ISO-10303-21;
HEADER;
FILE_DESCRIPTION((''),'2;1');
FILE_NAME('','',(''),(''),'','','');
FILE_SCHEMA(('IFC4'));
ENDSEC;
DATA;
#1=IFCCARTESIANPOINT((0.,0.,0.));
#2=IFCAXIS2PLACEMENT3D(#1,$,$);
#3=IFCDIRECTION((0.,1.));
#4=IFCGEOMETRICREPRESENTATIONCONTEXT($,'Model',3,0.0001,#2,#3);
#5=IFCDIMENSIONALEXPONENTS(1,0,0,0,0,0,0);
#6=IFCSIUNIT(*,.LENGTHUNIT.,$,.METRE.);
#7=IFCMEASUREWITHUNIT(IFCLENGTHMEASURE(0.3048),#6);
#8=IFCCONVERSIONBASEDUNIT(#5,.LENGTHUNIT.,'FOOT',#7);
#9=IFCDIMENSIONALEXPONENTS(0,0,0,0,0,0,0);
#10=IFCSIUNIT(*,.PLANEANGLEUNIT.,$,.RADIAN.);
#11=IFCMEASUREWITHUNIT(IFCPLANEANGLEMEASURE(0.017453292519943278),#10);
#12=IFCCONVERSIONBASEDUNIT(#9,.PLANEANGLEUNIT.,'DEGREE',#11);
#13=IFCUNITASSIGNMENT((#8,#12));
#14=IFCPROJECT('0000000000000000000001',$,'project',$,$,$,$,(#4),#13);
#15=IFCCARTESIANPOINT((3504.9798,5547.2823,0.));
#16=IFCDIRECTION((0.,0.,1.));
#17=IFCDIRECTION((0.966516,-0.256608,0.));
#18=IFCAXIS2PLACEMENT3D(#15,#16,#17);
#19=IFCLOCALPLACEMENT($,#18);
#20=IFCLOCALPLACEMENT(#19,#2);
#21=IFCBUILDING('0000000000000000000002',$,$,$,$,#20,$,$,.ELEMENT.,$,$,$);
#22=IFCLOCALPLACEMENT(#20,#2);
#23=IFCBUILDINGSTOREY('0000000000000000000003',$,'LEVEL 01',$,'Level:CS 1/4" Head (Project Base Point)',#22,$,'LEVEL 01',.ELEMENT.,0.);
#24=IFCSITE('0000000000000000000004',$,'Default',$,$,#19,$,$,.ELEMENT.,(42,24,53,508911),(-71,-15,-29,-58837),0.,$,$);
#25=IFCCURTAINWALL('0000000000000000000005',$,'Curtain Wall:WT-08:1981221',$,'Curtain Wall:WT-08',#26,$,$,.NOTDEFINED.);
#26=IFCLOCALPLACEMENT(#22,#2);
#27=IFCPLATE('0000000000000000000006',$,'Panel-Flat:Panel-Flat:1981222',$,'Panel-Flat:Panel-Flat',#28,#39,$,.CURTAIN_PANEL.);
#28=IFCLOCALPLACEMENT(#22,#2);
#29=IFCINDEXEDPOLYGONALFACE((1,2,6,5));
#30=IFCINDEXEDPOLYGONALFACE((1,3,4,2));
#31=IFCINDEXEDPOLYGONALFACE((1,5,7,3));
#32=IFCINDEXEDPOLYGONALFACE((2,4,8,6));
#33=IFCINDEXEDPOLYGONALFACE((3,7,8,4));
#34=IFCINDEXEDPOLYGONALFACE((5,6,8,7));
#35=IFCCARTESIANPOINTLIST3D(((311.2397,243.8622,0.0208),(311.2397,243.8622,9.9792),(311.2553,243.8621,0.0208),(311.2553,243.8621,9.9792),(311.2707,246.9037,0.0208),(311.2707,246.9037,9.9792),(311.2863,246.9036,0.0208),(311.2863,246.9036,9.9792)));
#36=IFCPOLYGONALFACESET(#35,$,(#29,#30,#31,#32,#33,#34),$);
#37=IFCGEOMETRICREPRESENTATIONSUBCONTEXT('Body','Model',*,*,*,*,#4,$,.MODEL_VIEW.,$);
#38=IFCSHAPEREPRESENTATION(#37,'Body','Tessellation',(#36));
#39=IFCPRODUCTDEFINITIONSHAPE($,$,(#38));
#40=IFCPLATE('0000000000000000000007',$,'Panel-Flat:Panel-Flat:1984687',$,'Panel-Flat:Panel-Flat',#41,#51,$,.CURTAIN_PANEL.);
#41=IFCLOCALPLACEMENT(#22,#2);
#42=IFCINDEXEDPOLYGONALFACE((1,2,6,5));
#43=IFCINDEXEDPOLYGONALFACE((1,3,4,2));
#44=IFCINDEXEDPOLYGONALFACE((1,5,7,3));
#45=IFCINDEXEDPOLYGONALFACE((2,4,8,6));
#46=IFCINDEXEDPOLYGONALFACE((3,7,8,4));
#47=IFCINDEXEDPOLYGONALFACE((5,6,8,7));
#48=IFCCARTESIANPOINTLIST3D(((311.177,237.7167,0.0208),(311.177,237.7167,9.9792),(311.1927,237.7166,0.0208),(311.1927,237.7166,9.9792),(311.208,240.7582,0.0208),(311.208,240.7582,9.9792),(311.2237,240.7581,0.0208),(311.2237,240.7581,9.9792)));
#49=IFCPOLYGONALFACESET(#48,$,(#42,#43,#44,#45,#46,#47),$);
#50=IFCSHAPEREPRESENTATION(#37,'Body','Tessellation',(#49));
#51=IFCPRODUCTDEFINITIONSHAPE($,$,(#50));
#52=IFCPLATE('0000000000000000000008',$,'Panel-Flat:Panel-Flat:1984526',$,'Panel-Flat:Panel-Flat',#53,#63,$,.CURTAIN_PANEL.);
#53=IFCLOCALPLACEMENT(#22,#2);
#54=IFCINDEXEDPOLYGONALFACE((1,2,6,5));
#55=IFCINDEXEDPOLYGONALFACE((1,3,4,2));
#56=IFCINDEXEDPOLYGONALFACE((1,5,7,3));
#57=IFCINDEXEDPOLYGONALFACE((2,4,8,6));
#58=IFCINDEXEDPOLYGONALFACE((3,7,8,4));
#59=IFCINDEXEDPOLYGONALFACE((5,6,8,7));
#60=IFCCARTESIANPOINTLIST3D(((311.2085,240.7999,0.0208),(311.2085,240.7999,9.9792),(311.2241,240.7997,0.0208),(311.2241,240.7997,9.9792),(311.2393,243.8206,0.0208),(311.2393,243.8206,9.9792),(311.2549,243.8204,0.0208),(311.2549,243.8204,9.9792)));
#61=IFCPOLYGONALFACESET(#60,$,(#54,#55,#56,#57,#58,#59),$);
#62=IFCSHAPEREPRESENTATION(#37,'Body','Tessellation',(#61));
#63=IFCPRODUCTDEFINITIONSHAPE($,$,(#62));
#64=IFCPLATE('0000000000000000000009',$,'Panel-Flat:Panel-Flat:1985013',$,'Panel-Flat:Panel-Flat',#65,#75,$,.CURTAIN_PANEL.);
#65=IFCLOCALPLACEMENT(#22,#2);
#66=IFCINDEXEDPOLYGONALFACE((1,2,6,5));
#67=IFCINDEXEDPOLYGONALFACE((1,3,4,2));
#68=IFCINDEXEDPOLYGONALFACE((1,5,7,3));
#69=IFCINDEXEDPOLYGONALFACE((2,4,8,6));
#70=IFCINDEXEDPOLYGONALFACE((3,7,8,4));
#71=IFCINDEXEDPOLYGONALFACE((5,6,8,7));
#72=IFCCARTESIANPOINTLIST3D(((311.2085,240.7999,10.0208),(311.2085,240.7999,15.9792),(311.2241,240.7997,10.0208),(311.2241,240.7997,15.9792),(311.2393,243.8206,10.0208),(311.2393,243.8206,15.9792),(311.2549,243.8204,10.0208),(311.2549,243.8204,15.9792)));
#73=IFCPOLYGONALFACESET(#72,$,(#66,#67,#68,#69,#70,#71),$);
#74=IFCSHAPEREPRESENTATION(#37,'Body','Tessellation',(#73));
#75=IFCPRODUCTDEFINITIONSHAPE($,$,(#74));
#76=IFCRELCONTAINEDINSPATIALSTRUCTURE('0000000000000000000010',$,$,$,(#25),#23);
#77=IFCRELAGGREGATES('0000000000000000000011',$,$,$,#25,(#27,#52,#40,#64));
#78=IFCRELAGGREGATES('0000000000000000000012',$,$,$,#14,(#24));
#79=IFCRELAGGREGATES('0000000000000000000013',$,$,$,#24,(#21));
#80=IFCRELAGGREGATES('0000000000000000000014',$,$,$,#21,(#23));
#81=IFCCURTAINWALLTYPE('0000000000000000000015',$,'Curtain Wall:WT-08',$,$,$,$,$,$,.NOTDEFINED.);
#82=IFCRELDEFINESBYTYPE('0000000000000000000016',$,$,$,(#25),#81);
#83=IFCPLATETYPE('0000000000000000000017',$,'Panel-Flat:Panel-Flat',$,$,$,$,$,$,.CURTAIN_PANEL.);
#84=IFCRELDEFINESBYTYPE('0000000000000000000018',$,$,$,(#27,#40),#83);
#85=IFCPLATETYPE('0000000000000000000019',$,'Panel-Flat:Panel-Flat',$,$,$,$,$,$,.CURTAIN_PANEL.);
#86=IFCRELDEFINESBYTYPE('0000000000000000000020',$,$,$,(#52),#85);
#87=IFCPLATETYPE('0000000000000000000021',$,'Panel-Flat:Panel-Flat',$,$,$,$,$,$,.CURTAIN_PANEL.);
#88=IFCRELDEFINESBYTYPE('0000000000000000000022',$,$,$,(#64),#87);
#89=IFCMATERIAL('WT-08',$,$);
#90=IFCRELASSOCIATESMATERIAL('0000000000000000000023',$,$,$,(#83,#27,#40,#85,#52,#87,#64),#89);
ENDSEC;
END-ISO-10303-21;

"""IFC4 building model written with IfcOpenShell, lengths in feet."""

from ifc_helpers import new_model, entity, si_unit, converted_unit, direction, frame, origin, place, context, subcontext, project, spatial, indexed_curve, outline, extrude, source, transform, mapped, material, type_object, type_shapes, element, aggregate, save


model = new_model("IFC4")

# Units and contexts
model_context = context("Model", 3, precision=0.0001, world=origin(), true_north=direction((0.0, 1.0)))
body_context = subcontext(model_context, "Body", "Model", "MODEL_VIEW")
ifc_project = project(units=[converted_unit("LENGTHUNIT", "FOOT", entity("IfcLengthMeasure", 0.3048), si_unit("LENGTHUNIT", "METRE"), dimensions=[1, 0, 0, 0, 0, 0, 0]), converted_unit("PLANEANGLEUNIT", "DEGREE", entity("IfcPlaneAngleMeasure", 0.017453292519943278), si_unit("PLANEANGLEUNIT", "RADIAN"), dimensions=[0, 0, 0, 0, 0, 0, 0])], contexts=[model_context])

# Site, building, storey
site_placement = place(None, frame((3504.9798, 5547.2823, 0.0), z_axis=(0.0, 0.0, 1.0), x_axis=(0.966516, -0.256608, 0.0)))
site = spatial("IfcSite", under=ifc_project, at=site_placement, Name="Default", CompositionType="ELEMENT", RefLatitude=(42, 24, 53, 508911), RefLongitude=(-71, -15, -29, -58837), RefElevation=0.0)
building_placement = place(site_placement, origin())
building = spatial("IfcBuilding", under=site, at=building_placement, CompositionType="ELEMENT")
storey_placement = place(building_placement, origin())
storey = spatial("IfcBuildingStorey", under=building, at=storey_placement, Name="LEVEL 01", ObjectType="Level:CS 1/4\" Head (Project Base Point)", LongName="LEVEL 01", CompositionType="ELEMENT", Elevation=0.0)

# Curtain wall
curtain_wall_type_1 = type_object("IfcCurtainWallType", Name="Curtain Wall:WT-08", PredefinedType="NOTDEFINED")
ifc_material_1 = material(Name="WT-08")
curtain_wall_1_placement = place(storey_placement, origin())
curtain_wall_1 = element("IfcCurtainWall", 1, at=curtain_wall_1_placement, inside=storey, type_object=curtain_wall_type_1, Name="Curtain Wall:WT-08:1981221", ObjectType="Curtain Wall:WT-08", PredefinedType="NOTDEFINED")

# Plates
plate_type_1 = type_object("IfcPlateType", Name="Panel-Flat:Panel-Flat", PredefinedType="CURTAIN_PANEL", material=ifc_material_1)
shared_shape_1 = source(origin(), body_context, "Body", "SweptSolid", [
    extrude(outline(indexed_curve([(-0.0078, -1.5208), (0.0078, -1.5208), (0.0078, 1.5208), (-0.0078, 1.5208), (-0.0078, -1.5208)], self_intersect=False)), frame((1.5208, 0.0078, 0.0), z_axis=(0.0, 0.0, 1.0), x_axis=(0.0, -1.0, 0.0)), (0.0, 0.0, 1.0), 9.9583),
])
type_shapes(plate_type_1, [shared_shape_1])
plate_1_placement = place(curtain_wall_1_placement, frame((311.2707, 246.9037, 0.0208), z_axis=(0.0, 0.0, 1.0), x_axis=(-0.010193, -0.999948, 0.0)))
plate_1 = element("IfcPlate", 2, at=plate_1_placement, type_object=plate_type_1, material=ifc_material_1, Name="Panel-Flat:Panel-Flat:1981222", ObjectType="Panel-Flat:Panel-Flat", PredefinedType="CURTAIN_PANEL", context=body_context, shape_type="MappedRepresentation", body=[
    mapped(shared_shape_1, transform((0.0, 0.0, 0.0), scale=1.0)),
])
plate_2_placement = place(curtain_wall_1_placement, frame((311.208, 240.7582, 0.0208), z_axis=(0.0, 0.0, 1.0), x_axis=(-0.010193, -0.999948, 0.0)))
plate_2 = element("IfcPlate", 3, at=plate_2_placement, type_object=plate_type_1, material=ifc_material_1, Name="Panel-Flat:Panel-Flat:1984687", ObjectType="Panel-Flat:Panel-Flat", PredefinedType="CURTAIN_PANEL", context=body_context, shape_type="MappedRepresentation", body=[
    mapped(shared_shape_1, transform((0.0, 0.0, 0.0), scale=1.0)),
])
plate_type_2 = type_object("IfcPlateType", Name="Panel-Flat:Panel-Flat", PredefinedType="CURTAIN_PANEL", material=ifc_material_1)
shared_shape_2 = source(origin(), body_context, "Body", "SweptSolid", [
    extrude(outline(indexed_curve([(-0.0078, -1.5104), (0.0078, -1.5104), (0.0078, 1.5104), (-0.0078, 1.5104), (-0.0078, -1.5104)], self_intersect=False)), frame((1.5104, 0.0078, 0.0), z_axis=(0.0, 0.0, 1.0), x_axis=(0.0, -1.0, 0.0)), (0.0, 0.0, 1.0), 9.9583),
])
type_shapes(plate_type_2, [shared_shape_2])
plate_3_placement = place(curtain_wall_1_placement, frame((311.2393, 243.8206, 0.0208), z_axis=(0.0, 0.0, 1.0), x_axis=(-0.010193, -0.999948, 0.0)))
plate_3 = element("IfcPlate", 4, at=plate_3_placement, type_object=plate_type_2, material=ifc_material_1, Name="Panel-Flat:Panel-Flat:1984526", ObjectType="Panel-Flat:Panel-Flat", PredefinedType="CURTAIN_PANEL", context=body_context, shape_type="MappedRepresentation", body=[
    mapped(shared_shape_2, transform((0.0, 0.0, 0.0), scale=1.0)),
])
plate_type_3 = type_object("IfcPlateType", Name="Panel-Flat:Panel-Flat", PredefinedType="CURTAIN_PANEL", material=ifc_material_1)
shared_shape_3 = source(origin(), body_context, "Body", "SweptSolid", [
    extrude(outline(indexed_curve([(-0.0078, -1.5104), (0.0078, -1.5104), (0.0078, 1.5104), (-0.0078, 1.5104), (-0.0078, -1.5104)], self_intersect=False)), frame((1.5104, 0.0078, 0.0), z_axis=(0.0, 0.0, 1.0), x_axis=(0.0, -1.0, 0.0)), (0.0, 0.0, 1.0), 5.9583),
])
type_shapes(plate_type_3, [shared_shape_3])
plate_4_placement = place(curtain_wall_1_placement, frame((311.2393, 243.8206, 10.0208), z_axis=(0.0, 0.0, 1.0), x_axis=(-0.010193, -0.999948, 0.0)))
plate_4 = element("IfcPlate", 5, at=plate_4_placement, type_object=plate_type_3, material=ifc_material_1, Name="Panel-Flat:Panel-Flat:1985013", ObjectType="Panel-Flat:Panel-Flat", PredefinedType="CURTAIN_PANEL", context=body_context, shape_type="MappedRepresentation", body=[
    mapped(shared_shape_3, transform((0.0, 0.0, 0.0), scale=1.0)),
])
aggregate(curtain_wall_1, [plate_1, plate_3, plate_2, plate_4])

save(model, "model.ifc")
